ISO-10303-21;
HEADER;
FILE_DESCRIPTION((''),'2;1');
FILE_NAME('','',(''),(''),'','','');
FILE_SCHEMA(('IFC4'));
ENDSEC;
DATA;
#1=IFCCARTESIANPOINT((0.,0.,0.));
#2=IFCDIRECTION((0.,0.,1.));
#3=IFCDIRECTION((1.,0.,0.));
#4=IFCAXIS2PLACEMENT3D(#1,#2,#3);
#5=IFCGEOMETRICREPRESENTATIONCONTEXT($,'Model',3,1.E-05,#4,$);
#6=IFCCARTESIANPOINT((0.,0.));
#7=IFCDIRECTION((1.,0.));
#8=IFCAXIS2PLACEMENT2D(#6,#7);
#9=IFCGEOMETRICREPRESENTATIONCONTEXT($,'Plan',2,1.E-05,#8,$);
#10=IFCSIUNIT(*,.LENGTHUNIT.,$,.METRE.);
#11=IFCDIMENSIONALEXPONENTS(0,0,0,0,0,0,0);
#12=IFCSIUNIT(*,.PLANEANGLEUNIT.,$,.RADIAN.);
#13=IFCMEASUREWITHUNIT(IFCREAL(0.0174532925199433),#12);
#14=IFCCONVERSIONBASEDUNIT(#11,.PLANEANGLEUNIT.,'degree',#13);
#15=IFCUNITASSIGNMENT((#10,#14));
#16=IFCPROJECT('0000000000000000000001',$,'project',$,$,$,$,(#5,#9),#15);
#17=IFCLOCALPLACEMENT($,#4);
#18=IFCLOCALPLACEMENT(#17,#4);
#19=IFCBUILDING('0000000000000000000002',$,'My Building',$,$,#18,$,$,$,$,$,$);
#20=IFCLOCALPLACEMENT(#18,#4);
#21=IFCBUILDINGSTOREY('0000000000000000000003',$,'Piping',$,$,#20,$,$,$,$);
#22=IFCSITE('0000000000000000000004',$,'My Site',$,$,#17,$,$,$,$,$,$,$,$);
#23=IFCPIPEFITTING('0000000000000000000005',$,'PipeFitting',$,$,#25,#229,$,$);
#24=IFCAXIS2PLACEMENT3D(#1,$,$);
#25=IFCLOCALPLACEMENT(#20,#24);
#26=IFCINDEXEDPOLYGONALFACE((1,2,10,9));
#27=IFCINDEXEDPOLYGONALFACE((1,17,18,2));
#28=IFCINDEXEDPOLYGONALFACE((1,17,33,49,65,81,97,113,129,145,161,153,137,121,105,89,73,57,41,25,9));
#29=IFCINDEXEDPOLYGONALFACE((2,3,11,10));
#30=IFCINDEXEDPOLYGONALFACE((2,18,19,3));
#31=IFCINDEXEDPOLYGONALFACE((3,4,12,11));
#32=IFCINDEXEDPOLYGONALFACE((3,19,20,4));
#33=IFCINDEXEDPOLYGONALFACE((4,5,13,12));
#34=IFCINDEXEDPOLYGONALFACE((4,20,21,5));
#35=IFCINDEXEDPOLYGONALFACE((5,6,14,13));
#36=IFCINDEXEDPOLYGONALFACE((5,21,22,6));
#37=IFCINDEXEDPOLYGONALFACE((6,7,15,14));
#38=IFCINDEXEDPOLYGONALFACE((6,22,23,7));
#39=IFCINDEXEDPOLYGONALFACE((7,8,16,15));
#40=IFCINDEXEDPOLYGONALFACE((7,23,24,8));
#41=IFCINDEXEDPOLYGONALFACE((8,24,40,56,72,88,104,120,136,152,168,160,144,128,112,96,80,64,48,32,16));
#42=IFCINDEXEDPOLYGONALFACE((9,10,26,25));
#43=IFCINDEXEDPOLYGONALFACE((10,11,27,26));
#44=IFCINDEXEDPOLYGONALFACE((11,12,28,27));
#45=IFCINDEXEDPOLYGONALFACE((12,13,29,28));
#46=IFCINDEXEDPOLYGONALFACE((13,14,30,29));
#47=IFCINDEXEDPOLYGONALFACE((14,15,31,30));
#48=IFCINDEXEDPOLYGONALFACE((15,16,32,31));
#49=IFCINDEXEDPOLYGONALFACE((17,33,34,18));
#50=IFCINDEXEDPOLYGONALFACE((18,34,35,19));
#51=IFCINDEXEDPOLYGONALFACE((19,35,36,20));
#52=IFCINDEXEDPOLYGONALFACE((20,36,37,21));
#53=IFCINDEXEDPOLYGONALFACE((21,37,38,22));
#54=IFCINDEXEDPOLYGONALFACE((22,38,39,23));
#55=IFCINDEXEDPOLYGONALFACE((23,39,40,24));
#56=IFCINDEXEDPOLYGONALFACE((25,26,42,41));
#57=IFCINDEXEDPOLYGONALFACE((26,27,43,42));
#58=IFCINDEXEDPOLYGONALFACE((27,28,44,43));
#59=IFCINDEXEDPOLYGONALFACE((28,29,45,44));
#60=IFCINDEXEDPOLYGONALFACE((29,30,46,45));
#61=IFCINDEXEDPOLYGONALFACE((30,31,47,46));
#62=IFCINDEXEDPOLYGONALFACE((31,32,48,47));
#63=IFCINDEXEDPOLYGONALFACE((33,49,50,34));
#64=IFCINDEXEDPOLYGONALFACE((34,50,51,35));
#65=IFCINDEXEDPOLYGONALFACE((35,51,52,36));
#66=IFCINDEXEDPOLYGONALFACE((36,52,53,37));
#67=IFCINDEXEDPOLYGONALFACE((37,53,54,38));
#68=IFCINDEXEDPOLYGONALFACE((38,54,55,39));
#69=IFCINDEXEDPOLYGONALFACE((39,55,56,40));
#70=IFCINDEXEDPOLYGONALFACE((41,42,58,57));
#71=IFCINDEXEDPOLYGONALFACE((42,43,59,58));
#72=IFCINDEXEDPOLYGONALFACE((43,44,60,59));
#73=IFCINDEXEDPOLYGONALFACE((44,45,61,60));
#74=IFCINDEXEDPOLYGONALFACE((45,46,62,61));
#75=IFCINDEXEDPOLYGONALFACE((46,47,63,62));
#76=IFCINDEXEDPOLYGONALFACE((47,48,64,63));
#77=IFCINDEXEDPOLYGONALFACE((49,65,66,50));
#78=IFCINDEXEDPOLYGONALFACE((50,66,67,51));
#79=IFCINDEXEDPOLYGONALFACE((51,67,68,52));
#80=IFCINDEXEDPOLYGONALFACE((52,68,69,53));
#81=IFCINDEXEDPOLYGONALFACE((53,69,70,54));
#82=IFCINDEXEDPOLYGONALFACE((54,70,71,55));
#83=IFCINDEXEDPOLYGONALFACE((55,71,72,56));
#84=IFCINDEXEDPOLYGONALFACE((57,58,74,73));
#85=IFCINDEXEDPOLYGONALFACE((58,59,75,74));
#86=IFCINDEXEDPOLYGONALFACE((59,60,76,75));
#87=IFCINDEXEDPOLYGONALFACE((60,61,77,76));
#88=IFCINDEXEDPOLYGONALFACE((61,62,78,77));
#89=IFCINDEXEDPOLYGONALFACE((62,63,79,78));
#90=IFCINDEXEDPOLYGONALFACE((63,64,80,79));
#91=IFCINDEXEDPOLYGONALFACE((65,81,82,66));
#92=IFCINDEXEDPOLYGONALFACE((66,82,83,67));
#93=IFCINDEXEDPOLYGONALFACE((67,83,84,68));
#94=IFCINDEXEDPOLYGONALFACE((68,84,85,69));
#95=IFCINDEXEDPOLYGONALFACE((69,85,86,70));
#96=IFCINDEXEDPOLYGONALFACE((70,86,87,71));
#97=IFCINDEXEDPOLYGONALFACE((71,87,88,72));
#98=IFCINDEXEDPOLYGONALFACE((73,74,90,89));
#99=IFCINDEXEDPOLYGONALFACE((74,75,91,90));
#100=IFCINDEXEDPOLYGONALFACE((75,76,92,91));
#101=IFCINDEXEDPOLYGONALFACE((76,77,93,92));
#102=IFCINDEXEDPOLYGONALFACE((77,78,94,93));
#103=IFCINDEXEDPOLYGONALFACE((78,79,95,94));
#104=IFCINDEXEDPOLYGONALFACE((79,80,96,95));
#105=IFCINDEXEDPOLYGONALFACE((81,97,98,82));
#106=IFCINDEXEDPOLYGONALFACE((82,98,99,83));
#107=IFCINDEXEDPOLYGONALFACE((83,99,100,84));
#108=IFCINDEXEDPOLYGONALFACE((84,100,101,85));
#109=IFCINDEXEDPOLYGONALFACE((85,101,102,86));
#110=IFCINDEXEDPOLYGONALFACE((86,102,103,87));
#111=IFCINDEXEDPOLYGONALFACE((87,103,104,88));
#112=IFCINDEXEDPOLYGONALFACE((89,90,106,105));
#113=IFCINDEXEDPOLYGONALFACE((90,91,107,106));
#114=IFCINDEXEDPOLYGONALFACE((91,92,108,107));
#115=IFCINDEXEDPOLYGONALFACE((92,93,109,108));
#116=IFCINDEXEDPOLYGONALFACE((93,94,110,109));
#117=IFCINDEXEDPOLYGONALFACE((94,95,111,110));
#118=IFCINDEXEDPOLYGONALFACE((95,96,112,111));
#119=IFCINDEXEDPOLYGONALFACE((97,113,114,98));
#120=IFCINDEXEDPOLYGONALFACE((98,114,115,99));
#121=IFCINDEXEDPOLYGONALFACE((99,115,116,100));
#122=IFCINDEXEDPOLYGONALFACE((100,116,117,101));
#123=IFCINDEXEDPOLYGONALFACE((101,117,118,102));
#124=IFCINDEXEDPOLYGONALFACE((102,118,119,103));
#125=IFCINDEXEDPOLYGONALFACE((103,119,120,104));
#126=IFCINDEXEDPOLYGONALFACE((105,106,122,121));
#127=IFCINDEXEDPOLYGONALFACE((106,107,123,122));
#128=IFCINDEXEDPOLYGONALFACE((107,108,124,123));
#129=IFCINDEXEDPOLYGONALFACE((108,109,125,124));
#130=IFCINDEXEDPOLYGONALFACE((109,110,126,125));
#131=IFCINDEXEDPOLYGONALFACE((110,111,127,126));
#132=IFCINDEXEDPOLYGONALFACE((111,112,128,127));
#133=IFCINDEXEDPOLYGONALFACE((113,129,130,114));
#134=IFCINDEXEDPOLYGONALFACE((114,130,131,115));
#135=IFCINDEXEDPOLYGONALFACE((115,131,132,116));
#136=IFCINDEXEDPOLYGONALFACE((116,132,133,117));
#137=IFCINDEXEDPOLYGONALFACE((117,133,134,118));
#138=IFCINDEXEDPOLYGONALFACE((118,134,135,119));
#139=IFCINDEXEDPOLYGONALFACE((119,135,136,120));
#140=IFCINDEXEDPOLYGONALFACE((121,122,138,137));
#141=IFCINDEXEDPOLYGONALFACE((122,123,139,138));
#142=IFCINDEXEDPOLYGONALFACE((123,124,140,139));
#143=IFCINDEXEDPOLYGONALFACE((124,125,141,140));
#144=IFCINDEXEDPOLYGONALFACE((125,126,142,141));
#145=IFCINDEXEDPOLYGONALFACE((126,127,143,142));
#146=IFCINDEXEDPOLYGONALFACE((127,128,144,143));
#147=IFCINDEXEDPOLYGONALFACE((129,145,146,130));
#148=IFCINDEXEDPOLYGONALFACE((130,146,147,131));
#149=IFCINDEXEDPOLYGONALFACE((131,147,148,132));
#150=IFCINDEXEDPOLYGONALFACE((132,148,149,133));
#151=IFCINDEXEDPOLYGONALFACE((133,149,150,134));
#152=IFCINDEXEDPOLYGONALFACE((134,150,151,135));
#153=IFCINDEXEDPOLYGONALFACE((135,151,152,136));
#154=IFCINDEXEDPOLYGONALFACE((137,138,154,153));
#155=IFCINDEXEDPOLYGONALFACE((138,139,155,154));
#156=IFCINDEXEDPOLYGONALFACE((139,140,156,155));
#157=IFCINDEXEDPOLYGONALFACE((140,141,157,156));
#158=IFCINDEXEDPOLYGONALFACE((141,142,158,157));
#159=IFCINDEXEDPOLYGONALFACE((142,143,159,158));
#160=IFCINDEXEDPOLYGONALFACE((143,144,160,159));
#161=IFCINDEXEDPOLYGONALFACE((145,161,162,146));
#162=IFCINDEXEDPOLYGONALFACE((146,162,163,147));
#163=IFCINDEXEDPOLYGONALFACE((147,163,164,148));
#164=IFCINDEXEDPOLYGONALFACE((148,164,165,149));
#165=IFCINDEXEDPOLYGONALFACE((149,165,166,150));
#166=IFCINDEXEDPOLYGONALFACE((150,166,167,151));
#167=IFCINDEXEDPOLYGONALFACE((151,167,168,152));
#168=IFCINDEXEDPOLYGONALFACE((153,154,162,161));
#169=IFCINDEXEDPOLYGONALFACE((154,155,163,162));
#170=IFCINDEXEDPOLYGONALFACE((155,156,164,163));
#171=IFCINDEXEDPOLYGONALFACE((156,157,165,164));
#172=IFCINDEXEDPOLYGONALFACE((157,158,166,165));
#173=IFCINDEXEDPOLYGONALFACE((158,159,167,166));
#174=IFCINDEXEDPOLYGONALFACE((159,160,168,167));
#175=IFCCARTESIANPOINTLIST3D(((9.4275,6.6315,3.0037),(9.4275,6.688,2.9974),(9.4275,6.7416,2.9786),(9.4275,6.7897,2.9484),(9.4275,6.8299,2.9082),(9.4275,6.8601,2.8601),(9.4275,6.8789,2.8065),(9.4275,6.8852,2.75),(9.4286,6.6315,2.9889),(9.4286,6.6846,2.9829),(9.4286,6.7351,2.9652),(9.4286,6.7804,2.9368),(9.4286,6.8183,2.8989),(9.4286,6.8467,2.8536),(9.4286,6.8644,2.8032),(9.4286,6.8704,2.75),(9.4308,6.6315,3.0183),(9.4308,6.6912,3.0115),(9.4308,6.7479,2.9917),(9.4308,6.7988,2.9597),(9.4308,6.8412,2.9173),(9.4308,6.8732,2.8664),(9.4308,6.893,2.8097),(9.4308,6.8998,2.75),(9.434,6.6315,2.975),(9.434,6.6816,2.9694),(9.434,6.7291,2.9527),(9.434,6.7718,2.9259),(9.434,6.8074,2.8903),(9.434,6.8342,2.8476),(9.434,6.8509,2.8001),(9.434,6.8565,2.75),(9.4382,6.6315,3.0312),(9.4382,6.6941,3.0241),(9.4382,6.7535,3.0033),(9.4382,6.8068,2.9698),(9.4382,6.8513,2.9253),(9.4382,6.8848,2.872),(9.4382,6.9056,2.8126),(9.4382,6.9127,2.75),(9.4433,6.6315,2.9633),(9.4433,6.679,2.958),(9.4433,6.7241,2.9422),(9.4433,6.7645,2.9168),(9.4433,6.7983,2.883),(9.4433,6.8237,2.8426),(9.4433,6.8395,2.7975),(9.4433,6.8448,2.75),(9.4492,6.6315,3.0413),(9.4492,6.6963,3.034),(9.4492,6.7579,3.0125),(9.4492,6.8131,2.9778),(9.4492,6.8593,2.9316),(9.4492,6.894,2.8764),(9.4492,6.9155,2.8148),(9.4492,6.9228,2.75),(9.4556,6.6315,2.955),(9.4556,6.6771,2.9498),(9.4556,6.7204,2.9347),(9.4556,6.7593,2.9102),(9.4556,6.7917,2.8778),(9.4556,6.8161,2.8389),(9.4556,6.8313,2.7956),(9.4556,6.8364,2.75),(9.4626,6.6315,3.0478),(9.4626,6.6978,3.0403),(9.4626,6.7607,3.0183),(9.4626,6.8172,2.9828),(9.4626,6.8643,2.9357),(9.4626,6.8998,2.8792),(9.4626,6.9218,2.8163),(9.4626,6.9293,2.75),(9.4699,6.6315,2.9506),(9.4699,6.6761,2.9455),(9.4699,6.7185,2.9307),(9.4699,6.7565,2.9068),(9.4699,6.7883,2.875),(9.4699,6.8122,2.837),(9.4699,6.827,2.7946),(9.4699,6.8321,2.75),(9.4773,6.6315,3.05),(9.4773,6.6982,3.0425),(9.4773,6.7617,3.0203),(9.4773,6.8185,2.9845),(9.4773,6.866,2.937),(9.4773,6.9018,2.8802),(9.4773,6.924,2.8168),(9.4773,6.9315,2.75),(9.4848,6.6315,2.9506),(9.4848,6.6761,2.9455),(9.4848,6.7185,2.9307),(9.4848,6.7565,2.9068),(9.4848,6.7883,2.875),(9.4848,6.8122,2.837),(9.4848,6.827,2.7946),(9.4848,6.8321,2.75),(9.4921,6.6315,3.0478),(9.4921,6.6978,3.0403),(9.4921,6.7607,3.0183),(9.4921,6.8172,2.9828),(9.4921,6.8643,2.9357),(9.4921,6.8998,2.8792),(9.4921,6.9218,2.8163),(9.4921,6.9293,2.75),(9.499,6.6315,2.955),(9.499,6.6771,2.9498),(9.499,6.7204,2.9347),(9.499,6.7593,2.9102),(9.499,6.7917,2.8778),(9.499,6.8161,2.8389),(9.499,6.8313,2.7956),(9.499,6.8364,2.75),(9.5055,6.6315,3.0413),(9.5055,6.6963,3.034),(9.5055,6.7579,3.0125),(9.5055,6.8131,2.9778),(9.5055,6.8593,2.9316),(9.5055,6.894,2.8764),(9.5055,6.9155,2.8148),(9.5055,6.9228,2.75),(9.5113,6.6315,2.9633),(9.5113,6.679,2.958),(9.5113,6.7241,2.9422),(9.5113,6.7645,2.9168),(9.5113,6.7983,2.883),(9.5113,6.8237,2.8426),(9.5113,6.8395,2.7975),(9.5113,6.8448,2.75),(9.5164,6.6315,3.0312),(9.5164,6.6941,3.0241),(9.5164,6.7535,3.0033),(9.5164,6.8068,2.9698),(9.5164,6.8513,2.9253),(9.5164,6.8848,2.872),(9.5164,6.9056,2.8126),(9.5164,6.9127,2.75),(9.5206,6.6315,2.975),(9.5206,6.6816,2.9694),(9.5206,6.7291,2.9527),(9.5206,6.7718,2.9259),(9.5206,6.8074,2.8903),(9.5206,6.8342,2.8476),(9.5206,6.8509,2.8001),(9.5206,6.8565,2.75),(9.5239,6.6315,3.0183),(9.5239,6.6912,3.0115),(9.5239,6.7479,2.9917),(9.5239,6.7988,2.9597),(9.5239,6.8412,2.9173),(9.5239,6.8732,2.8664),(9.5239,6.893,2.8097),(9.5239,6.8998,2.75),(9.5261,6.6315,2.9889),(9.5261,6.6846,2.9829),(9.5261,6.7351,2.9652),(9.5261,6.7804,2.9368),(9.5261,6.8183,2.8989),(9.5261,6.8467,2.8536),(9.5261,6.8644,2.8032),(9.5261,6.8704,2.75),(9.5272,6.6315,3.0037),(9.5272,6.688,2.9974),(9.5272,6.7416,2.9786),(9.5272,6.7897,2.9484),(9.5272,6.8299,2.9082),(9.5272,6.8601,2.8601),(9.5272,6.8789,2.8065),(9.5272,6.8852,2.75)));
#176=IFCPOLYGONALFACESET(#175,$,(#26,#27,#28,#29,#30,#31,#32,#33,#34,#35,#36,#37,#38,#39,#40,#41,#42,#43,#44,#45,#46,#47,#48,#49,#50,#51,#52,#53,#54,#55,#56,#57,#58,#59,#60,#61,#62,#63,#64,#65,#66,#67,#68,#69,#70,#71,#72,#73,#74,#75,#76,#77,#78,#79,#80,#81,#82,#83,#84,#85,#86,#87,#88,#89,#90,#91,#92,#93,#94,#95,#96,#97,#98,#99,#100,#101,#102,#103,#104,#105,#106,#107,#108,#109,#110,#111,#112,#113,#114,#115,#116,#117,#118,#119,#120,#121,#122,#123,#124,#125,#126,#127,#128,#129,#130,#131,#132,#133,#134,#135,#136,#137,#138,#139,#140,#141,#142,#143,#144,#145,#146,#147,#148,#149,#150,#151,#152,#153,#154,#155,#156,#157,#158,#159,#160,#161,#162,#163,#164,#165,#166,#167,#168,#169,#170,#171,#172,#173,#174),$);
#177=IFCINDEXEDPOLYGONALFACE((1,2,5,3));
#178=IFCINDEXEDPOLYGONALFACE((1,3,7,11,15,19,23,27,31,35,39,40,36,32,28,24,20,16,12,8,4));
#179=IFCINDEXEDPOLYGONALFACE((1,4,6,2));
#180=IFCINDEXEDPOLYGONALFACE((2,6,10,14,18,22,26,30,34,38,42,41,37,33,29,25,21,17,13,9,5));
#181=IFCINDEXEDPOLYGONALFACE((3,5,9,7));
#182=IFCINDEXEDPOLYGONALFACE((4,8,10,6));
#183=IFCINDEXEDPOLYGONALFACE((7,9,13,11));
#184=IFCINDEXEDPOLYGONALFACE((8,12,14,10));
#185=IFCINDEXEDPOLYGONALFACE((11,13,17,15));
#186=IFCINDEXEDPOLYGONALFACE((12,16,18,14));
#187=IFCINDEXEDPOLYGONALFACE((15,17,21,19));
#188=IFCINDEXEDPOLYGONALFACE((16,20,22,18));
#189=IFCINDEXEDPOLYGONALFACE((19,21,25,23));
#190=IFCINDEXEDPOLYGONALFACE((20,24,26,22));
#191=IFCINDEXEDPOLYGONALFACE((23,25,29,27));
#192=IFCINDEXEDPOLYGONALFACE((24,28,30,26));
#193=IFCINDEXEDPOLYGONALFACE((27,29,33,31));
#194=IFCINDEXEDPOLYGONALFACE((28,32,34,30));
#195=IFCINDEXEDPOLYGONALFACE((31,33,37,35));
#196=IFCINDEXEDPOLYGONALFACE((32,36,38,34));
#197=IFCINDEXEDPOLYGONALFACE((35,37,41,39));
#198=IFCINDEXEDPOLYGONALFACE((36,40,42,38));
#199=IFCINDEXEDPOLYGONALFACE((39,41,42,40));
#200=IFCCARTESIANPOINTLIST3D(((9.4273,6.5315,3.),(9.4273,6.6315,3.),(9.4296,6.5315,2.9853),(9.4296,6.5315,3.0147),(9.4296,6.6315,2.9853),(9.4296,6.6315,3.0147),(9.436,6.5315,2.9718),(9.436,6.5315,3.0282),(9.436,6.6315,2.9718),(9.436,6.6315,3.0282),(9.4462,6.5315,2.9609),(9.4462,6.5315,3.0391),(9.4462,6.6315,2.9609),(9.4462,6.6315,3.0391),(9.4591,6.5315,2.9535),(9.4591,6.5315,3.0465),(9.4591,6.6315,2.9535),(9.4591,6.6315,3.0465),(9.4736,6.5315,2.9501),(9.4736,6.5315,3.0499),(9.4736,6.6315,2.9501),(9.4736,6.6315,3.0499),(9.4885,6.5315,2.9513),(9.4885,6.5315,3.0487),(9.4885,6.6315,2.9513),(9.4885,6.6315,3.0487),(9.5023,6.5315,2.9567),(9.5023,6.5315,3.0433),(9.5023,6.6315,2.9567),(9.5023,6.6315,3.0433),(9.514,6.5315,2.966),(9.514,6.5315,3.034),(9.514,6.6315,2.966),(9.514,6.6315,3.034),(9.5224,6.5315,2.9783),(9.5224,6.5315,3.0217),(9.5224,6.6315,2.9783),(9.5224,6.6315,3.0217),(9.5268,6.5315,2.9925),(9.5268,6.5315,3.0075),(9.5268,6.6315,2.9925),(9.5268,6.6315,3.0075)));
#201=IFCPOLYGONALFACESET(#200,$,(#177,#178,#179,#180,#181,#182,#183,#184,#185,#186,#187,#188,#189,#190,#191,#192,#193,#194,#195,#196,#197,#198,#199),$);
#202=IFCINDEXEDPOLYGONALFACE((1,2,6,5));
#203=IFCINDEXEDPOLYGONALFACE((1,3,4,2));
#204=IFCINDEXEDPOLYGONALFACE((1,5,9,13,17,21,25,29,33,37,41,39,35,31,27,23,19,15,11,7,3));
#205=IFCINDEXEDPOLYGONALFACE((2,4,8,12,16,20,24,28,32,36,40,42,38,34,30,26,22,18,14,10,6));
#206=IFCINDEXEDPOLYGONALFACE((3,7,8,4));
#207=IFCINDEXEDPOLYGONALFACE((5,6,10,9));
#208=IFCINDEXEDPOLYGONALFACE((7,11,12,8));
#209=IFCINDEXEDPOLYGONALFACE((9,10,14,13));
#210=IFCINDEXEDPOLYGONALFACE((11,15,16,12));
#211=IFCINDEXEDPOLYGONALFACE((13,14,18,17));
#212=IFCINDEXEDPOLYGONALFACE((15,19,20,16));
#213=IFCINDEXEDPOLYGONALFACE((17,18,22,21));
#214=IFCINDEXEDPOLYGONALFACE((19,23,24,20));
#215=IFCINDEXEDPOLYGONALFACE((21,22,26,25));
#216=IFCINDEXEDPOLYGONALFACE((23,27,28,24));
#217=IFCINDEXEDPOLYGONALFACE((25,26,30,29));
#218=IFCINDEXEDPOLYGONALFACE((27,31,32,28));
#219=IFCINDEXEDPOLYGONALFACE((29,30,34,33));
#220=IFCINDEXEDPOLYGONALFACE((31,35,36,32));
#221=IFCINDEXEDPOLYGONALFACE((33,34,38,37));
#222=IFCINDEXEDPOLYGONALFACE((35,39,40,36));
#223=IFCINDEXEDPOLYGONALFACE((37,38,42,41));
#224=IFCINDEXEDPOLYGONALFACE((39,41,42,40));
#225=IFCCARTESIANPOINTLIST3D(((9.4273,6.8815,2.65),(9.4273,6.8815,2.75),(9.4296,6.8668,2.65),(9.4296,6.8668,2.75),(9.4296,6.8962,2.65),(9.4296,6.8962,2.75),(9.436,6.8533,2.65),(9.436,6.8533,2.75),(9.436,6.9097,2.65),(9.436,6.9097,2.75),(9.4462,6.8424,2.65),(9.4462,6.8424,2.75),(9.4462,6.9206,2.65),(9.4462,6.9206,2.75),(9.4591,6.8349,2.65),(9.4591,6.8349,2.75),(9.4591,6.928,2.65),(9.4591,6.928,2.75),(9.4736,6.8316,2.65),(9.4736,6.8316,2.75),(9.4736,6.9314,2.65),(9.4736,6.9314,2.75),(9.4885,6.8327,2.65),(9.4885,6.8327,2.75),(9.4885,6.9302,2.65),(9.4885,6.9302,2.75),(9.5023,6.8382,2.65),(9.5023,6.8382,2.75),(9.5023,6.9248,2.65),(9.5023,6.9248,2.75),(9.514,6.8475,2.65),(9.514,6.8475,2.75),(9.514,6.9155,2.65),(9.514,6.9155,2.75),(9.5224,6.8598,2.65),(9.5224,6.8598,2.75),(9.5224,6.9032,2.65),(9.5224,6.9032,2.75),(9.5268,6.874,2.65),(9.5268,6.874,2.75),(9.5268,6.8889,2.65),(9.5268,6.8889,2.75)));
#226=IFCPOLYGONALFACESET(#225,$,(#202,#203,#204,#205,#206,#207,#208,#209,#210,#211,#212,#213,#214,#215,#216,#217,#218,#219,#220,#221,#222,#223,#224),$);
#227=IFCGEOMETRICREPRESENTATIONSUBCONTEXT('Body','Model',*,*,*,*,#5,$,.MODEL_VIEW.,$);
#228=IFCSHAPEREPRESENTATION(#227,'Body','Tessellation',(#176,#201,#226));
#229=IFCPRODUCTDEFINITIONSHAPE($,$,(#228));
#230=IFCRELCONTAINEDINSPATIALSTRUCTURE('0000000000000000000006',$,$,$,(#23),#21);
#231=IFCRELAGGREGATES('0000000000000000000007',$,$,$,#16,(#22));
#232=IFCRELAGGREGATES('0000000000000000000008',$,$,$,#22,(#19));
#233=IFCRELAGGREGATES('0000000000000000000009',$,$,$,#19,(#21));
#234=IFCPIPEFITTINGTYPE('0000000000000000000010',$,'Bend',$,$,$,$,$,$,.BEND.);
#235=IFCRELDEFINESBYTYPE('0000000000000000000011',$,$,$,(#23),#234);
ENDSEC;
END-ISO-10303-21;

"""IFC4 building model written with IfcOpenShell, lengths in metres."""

from ifc_helpers import new_model, entity, si_unit, converted_unit, frame, origin_with_axes, origin_2d_with_axis, place, context, subcontext, project, spatial, circle, extrude, source, transform, mapped, type_object, type_shapes, element, save


model = new_model("IFC4")

# Units and contexts
model_context = context("Model", 3, precision=1e-05, world=origin_with_axes())
plan_context = context("Plan", 2, precision=1e-05, world=origin_2d_with_axis())
body_context = subcontext(model_context, "Body", "Model", "MODEL_VIEW")
ifc_project = project(units=[si_unit("LENGTHUNIT", "METRE"), converted_unit("PLANEANGLEUNIT", "degree", entity("IfcReal", 0.0174532925199433), si_unit("PLANEANGLEUNIT", "RADIAN"), dimensions=[0, 0, 0, 0, 0, 0, 0])], contexts=[model_context, plan_context])

# Site, building, storey
site_placement = place(None, origin_with_axes())
site = spatial("IfcSite", under=ifc_project, at=site_placement, Name="My Site")
building_placement = place(site_placement, origin_with_axes())
building = spatial("IfcBuilding", under=site, at=building_placement, Name="My Building")
storey_placement = place(building_placement, origin_with_axes())
storey = spatial("IfcBuildingStorey", under=building, at=storey_placement, Name="Piping")

# Pipe fitting
pipe_fitting_type_1 = type_object("IfcPipeFittingType", Name="Bend", PredefinedType="BEND")
shared_shape = source(origin_with_axes(), body_context, "Body", "SolidModel", [
    entity("IfcSweptDiskSolid", entity("IfcIndexedPolyCurve", entity("IfcCartesianPointList3D", [[0.0, 0.0, -0.1], [0.0, 0.0732, -0.2768], [0.0, 0.25, -0.35]]), [entity("IfcArcIndex", [1, 2, 3])]), 0.05),
    extrude(circle(Radius=0.05), origin_with_axes(), (0.0, 0.0, -1.0), 0.1),
    extrude(circle(Radius=0.05), frame((0.0, 0.25, -0.35), z_axis=(0.0, 1.0, 0.0), x_axis=(1.0, 0.0, 0.0)), (0.0, 0.0, 1.0), 0.1),
])
type_shapes(pipe_fitting_type_1, [shared_shape])
for number, where, z_axis, x_axis, name in (
    (1, (9.4773, 6.5315, 3.0), (0.0, -1.0, 0.0), (-1.0, 0.0, 0.0), "PipeFitting"),
):
    element("IfcPipeFitting", number, at=place(storey_placement, frame(where, z_axis=z_axis, x_axis=x_axis)), inside=storey, type_object=pipe_fitting_type_1, Name=name, context=body_context, shape_type="MappedRepresentation", body=[
        mapped(shared_shape, transform((0.0, 0.0, 0.0), x_axis=(1.0, 0.0, 0.0), y_axis=(0.0, 1.0, 0.0), z_axis=(0.0, 0.0, 1.0), scale=1.0)),
    ])

save(model, "model.ifc")
